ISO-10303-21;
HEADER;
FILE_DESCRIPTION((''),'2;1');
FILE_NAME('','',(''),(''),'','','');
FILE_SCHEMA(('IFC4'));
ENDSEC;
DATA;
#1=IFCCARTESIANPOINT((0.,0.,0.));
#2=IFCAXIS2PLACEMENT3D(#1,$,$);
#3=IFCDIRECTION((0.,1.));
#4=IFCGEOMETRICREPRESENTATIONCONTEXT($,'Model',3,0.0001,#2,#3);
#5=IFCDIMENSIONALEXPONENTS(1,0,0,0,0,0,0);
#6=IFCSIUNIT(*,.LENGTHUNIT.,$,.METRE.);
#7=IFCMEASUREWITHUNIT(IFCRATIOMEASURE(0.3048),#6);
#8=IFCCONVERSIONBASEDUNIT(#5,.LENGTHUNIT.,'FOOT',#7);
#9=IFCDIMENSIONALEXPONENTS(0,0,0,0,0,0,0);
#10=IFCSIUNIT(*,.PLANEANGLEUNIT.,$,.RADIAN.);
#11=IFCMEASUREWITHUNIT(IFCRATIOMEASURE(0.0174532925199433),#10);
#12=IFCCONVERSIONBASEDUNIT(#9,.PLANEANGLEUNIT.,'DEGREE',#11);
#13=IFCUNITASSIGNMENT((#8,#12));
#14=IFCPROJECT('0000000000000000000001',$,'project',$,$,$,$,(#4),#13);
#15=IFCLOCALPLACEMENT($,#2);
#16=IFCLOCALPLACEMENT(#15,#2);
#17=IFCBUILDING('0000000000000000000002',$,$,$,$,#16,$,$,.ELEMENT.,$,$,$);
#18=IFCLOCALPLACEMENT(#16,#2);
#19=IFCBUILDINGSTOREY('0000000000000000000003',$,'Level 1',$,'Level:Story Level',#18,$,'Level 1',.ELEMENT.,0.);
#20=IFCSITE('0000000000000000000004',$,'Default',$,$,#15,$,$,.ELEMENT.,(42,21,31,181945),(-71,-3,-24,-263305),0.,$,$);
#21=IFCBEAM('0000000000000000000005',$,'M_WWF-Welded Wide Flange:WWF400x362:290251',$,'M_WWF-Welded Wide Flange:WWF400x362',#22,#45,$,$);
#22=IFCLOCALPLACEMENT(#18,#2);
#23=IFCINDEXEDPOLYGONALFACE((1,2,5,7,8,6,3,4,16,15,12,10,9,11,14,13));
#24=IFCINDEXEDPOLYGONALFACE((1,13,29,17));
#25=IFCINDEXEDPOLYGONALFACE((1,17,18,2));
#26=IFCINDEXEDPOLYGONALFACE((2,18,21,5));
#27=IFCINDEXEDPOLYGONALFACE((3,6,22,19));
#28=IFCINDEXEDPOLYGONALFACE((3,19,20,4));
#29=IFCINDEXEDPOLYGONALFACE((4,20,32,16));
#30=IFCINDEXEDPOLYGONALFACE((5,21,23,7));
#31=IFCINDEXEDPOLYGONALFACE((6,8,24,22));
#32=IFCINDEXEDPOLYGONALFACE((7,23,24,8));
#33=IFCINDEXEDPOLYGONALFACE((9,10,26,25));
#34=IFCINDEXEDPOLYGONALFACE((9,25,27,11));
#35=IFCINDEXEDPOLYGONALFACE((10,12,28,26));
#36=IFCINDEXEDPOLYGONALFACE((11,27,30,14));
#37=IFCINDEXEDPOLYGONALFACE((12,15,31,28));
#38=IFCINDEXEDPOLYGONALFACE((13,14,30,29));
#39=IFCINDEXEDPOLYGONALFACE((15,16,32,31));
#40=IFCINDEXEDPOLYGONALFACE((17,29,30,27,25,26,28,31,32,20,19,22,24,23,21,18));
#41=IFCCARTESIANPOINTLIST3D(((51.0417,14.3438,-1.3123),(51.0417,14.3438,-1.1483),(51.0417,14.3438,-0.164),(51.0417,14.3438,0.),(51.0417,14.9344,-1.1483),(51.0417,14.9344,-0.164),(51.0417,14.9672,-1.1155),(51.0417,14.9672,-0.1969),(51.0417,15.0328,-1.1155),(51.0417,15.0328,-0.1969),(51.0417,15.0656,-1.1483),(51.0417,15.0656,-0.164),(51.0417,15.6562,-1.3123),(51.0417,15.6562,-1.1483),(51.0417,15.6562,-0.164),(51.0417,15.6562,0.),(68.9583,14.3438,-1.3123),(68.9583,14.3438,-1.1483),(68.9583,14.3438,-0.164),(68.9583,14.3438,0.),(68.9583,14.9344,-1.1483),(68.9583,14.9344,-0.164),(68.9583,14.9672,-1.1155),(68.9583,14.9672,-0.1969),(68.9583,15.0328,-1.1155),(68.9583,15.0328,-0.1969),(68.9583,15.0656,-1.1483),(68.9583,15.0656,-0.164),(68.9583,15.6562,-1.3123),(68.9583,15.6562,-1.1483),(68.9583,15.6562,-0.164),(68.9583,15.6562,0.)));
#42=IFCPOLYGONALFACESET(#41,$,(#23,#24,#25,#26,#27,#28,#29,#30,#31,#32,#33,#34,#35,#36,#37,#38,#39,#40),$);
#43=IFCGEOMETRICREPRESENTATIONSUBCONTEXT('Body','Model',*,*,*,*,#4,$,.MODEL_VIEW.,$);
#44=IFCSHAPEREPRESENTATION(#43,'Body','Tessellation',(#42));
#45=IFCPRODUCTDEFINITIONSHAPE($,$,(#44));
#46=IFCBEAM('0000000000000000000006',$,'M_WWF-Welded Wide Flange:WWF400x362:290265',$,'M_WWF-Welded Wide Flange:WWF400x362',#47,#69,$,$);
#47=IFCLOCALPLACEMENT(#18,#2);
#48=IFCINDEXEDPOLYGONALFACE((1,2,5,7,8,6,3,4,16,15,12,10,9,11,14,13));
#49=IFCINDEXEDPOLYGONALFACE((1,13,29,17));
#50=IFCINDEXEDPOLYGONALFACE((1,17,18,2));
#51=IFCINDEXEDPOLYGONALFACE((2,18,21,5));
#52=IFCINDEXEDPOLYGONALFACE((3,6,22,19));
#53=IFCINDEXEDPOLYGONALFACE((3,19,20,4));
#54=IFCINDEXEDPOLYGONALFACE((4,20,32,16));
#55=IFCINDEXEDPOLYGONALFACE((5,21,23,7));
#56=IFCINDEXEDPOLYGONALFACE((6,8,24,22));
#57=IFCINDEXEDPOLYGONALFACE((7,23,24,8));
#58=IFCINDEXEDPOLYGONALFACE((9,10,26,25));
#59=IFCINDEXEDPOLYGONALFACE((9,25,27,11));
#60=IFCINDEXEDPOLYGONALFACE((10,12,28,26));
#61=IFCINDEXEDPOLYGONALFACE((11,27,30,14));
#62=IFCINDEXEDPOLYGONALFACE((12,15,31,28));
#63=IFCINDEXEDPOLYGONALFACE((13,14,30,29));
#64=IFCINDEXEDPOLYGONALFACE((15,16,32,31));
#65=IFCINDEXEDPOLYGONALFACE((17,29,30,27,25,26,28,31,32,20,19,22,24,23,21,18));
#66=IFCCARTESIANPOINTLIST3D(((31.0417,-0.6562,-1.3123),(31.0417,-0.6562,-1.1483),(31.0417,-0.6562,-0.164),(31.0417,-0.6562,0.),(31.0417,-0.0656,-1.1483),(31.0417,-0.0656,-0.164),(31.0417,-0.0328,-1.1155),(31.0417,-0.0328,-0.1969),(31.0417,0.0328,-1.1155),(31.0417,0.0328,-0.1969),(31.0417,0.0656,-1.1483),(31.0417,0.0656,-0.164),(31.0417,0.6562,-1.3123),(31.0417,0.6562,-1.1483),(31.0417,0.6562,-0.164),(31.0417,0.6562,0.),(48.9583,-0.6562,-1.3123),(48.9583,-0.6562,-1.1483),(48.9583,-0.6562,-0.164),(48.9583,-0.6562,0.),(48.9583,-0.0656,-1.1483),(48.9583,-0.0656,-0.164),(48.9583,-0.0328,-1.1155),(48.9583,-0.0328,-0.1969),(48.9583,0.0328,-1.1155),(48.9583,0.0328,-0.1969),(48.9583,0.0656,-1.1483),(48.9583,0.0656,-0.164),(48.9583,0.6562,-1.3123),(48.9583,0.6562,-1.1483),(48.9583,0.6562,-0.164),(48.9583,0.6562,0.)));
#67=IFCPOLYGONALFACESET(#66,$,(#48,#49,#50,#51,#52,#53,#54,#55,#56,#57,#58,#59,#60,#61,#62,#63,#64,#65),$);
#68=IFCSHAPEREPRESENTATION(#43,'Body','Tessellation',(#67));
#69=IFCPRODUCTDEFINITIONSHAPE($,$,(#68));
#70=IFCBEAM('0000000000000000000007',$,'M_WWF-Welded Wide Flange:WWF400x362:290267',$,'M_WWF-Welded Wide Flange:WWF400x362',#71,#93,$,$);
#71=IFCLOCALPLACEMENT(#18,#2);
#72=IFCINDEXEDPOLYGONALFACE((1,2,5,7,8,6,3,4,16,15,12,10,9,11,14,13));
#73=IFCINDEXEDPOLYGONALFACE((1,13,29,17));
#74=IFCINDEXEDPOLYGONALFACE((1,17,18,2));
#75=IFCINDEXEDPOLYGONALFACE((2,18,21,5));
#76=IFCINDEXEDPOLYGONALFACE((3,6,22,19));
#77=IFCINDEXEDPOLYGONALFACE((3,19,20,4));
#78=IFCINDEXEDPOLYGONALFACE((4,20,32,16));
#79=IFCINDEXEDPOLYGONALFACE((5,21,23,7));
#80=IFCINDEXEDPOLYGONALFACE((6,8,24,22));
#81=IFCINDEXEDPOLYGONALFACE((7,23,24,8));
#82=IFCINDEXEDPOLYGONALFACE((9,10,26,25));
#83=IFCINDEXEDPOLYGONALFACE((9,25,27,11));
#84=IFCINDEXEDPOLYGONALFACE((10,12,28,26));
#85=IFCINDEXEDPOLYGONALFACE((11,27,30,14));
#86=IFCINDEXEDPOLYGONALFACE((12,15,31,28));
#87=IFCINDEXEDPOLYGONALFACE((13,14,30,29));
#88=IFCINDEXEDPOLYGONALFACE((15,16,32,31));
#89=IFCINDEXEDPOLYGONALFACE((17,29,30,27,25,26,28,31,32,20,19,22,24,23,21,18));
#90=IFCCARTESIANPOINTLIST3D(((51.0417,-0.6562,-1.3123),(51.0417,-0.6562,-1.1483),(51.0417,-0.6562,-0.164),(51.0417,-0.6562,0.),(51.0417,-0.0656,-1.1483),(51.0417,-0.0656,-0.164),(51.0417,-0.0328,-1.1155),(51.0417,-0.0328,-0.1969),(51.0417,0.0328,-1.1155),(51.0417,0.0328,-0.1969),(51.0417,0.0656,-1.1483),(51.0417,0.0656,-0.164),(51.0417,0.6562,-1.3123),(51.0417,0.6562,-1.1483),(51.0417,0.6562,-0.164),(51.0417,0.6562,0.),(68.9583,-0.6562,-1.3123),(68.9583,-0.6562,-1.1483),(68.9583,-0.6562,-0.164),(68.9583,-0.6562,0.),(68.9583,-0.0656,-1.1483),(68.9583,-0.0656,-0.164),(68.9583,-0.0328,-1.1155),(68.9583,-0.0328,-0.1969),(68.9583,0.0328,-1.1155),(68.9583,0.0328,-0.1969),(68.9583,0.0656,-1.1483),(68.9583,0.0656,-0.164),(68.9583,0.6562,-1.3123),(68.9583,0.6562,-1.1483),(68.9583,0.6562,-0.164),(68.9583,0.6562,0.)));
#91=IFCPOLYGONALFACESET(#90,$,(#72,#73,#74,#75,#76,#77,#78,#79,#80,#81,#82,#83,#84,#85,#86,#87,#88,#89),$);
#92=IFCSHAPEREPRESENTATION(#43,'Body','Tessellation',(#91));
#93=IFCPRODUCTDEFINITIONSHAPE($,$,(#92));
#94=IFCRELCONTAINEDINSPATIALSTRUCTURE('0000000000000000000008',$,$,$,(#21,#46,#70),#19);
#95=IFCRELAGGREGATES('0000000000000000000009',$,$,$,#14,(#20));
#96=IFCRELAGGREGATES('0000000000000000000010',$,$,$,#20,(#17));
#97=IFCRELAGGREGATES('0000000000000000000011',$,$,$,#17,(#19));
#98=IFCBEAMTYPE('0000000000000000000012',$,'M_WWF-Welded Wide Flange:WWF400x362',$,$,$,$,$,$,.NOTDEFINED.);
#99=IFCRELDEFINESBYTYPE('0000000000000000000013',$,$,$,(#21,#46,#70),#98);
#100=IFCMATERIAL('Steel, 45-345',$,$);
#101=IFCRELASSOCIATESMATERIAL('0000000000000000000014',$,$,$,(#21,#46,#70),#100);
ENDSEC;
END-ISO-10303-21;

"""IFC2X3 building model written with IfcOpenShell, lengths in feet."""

from ifc_helpers import new_model, entity, si_unit, converted_unit, direction, frame, origin, place, context, subcontext, project, spatial, polyline, outline, extrude, material, type_object, element, save


model = new_model("IFC2X3")

# Units and contexts
model_context = context("Model", 3, precision=0.0001, world=origin(), true_north=direction((0.0, 1.0)))
body_context = subcontext(model_context, "Body", "Model", "MODEL_VIEW")
ifc_project = project(units=[converted_unit("LENGTHUNIT", "FOOT", entity("IfcRatioMeasure", 0.3048), si_unit("LENGTHUNIT", "METRE"), dimensions=[1, 0, 0, 0, 0, 0, 0]), converted_unit("PLANEANGLEUNIT", "DEGREE", entity("IfcRatioMeasure", 0.0174532925199433), si_unit("PLANEANGLEUNIT", "RADIAN"), dimensions=[0, 0, 0, 0, 0, 0, 0])], contexts=[model_context])

# Site, building, storey
site_placement = place(None, origin())
site = spatial("IfcSite", under=ifc_project, at=site_placement, Name="Default", CompositionType="ELEMENT", RefLatitude=(42, 21, 31, 181945), RefLongitude=(-71, -3, -24, -263305), RefElevation=0.0)
building_placement = place(site_placement, origin())
building = spatial("IfcBuilding", under=site, at=building_placement, CompositionType="ELEMENT")
storey_placement = place(building_placement, origin())
storey = spatial("IfcBuildingStorey", under=building, at=storey_placement, Name="Level 1", ObjectType="Level:Story Level", LongName="Level 1", CompositionType="ELEMENT", Elevation=0.0)

# Shared definitions
ifc_material = material(Name="Steel, 45-345")

# Beams
beam_type = type_object("IfcBeamType", Name="M_WWF-Welded Wide Flange:WWF400x362", PredefinedType="NOTDEFINED")
beam_1_placement = place(storey_placement, frame((50.0, 15.0, 0.0)))
element("IfcBeam", 1, at=beam_1_placement, inside=storey, type_object=beam_type, material=ifc_material, Name="M_WWF-Welded Wide Flange:WWF400x362:290251", ObjectType="M_WWF-Welded Wide Flange:WWF400x362", context=body_context, shape_type="SweptSolid", body=[
    extrude(outline(polyline([(-0.6562, -0.6562), (-0.4921, -0.6562), (-0.4921, -0.0656), (-0.4593, -0.0328), (0.4593, -0.0328), (0.4921, -0.0656), (0.4921, -0.6562), (0.6562, -0.6562), (0.6562, 0.6562), (0.4921, 0.6562), (0.4921, 0.0656), (0.4593, 0.0328), (-0.4593, 0.0328), (-0.4921, 0.0656), (-0.4921, 0.6562), (-0.6562, 0.6562), (-0.6562, -0.6562)])), frame((1.0417, 0.0, -0.6562), z_axis=(1.0, 0.0, 0.0), x_axis=(0.0, 0.0, -1.0)), (0.0, 0.0, 1.0), 17.9167),
])
beam_2_placement = place(storey_placement, frame((30.0, 0.0, 0.0)))
element("IfcBeam", 2, at=beam_2_placement, inside=storey, type_object=beam_type, material=ifc_material, Name="M_WWF-Welded Wide Flange:WWF400x362:290265", ObjectType="M_WWF-Welded Wide Flange:WWF400x362", context=body_context, shape_type="SweptSolid", body=[
    extrude(outline(polyline([(-0.6562, -0.6562), (-0.4921, -0.6562), (-0.4921, -0.0656), (-0.4593, -0.0328), (0.4593, -0.0328), (0.4921, -0.0656), (0.4921, -0.6562), (0.6562, -0.6562), (0.6562, 0.6562), (0.4921, 0.6562), (0.4921, 0.0656), (0.4593, 0.0328), (-0.4593, 0.0328), (-0.4921, 0.0656), (-0.4921, 0.6562), (-0.6562, 0.6562), (-0.6562, -0.6562)])), frame((1.0417, 0.0, -0.6562), z_axis=(1.0, 0.0, 0.0), x_axis=(0.0, 0.0, -1.0)), (0.0, 0.0, 1.0), 17.9167),
])
beam_3_placement = place(storey_placement, frame((50.0, 0.0, 0.0)))
element("IfcBeam", 3, at=beam_3_placement, inside=storey, type_object=beam_type, material=ifc_material, Name="M_WWF-Welded Wide Flange:WWF400x362:290267", ObjectType="M_WWF-Welded Wide Flange:WWF400x362", context=body_context, shape_type="SweptSolid", body=[
    extrude(outline(polyline([(-0.6562, -0.6562), (-0.4921, -0.6562), (-0.4921, -0.0656), (-0.4593, -0.0328), (0.4593, -0.0328), (0.4921, -0.0656), (0.4921, -0.6562), (0.6562, -0.6562), (0.6562, 0.6562), (0.4921, 0.6562), (0.4921, 0.0656), (0.4593, 0.0328), (-0.4593, 0.0328), (-0.4921, 0.0656), (-0.4921, 0.6562), (-0.6562, 0.6562), (-0.6562, -0.6562)])), frame((1.0417, 0.0, -0.6562), z_axis=(1.0, 0.0, 0.0), x_axis=(0.0, 0.0, -1.0)), (0.0, 0.0, 1.0), 17.9167),
])

save(model, "model.ifc")
